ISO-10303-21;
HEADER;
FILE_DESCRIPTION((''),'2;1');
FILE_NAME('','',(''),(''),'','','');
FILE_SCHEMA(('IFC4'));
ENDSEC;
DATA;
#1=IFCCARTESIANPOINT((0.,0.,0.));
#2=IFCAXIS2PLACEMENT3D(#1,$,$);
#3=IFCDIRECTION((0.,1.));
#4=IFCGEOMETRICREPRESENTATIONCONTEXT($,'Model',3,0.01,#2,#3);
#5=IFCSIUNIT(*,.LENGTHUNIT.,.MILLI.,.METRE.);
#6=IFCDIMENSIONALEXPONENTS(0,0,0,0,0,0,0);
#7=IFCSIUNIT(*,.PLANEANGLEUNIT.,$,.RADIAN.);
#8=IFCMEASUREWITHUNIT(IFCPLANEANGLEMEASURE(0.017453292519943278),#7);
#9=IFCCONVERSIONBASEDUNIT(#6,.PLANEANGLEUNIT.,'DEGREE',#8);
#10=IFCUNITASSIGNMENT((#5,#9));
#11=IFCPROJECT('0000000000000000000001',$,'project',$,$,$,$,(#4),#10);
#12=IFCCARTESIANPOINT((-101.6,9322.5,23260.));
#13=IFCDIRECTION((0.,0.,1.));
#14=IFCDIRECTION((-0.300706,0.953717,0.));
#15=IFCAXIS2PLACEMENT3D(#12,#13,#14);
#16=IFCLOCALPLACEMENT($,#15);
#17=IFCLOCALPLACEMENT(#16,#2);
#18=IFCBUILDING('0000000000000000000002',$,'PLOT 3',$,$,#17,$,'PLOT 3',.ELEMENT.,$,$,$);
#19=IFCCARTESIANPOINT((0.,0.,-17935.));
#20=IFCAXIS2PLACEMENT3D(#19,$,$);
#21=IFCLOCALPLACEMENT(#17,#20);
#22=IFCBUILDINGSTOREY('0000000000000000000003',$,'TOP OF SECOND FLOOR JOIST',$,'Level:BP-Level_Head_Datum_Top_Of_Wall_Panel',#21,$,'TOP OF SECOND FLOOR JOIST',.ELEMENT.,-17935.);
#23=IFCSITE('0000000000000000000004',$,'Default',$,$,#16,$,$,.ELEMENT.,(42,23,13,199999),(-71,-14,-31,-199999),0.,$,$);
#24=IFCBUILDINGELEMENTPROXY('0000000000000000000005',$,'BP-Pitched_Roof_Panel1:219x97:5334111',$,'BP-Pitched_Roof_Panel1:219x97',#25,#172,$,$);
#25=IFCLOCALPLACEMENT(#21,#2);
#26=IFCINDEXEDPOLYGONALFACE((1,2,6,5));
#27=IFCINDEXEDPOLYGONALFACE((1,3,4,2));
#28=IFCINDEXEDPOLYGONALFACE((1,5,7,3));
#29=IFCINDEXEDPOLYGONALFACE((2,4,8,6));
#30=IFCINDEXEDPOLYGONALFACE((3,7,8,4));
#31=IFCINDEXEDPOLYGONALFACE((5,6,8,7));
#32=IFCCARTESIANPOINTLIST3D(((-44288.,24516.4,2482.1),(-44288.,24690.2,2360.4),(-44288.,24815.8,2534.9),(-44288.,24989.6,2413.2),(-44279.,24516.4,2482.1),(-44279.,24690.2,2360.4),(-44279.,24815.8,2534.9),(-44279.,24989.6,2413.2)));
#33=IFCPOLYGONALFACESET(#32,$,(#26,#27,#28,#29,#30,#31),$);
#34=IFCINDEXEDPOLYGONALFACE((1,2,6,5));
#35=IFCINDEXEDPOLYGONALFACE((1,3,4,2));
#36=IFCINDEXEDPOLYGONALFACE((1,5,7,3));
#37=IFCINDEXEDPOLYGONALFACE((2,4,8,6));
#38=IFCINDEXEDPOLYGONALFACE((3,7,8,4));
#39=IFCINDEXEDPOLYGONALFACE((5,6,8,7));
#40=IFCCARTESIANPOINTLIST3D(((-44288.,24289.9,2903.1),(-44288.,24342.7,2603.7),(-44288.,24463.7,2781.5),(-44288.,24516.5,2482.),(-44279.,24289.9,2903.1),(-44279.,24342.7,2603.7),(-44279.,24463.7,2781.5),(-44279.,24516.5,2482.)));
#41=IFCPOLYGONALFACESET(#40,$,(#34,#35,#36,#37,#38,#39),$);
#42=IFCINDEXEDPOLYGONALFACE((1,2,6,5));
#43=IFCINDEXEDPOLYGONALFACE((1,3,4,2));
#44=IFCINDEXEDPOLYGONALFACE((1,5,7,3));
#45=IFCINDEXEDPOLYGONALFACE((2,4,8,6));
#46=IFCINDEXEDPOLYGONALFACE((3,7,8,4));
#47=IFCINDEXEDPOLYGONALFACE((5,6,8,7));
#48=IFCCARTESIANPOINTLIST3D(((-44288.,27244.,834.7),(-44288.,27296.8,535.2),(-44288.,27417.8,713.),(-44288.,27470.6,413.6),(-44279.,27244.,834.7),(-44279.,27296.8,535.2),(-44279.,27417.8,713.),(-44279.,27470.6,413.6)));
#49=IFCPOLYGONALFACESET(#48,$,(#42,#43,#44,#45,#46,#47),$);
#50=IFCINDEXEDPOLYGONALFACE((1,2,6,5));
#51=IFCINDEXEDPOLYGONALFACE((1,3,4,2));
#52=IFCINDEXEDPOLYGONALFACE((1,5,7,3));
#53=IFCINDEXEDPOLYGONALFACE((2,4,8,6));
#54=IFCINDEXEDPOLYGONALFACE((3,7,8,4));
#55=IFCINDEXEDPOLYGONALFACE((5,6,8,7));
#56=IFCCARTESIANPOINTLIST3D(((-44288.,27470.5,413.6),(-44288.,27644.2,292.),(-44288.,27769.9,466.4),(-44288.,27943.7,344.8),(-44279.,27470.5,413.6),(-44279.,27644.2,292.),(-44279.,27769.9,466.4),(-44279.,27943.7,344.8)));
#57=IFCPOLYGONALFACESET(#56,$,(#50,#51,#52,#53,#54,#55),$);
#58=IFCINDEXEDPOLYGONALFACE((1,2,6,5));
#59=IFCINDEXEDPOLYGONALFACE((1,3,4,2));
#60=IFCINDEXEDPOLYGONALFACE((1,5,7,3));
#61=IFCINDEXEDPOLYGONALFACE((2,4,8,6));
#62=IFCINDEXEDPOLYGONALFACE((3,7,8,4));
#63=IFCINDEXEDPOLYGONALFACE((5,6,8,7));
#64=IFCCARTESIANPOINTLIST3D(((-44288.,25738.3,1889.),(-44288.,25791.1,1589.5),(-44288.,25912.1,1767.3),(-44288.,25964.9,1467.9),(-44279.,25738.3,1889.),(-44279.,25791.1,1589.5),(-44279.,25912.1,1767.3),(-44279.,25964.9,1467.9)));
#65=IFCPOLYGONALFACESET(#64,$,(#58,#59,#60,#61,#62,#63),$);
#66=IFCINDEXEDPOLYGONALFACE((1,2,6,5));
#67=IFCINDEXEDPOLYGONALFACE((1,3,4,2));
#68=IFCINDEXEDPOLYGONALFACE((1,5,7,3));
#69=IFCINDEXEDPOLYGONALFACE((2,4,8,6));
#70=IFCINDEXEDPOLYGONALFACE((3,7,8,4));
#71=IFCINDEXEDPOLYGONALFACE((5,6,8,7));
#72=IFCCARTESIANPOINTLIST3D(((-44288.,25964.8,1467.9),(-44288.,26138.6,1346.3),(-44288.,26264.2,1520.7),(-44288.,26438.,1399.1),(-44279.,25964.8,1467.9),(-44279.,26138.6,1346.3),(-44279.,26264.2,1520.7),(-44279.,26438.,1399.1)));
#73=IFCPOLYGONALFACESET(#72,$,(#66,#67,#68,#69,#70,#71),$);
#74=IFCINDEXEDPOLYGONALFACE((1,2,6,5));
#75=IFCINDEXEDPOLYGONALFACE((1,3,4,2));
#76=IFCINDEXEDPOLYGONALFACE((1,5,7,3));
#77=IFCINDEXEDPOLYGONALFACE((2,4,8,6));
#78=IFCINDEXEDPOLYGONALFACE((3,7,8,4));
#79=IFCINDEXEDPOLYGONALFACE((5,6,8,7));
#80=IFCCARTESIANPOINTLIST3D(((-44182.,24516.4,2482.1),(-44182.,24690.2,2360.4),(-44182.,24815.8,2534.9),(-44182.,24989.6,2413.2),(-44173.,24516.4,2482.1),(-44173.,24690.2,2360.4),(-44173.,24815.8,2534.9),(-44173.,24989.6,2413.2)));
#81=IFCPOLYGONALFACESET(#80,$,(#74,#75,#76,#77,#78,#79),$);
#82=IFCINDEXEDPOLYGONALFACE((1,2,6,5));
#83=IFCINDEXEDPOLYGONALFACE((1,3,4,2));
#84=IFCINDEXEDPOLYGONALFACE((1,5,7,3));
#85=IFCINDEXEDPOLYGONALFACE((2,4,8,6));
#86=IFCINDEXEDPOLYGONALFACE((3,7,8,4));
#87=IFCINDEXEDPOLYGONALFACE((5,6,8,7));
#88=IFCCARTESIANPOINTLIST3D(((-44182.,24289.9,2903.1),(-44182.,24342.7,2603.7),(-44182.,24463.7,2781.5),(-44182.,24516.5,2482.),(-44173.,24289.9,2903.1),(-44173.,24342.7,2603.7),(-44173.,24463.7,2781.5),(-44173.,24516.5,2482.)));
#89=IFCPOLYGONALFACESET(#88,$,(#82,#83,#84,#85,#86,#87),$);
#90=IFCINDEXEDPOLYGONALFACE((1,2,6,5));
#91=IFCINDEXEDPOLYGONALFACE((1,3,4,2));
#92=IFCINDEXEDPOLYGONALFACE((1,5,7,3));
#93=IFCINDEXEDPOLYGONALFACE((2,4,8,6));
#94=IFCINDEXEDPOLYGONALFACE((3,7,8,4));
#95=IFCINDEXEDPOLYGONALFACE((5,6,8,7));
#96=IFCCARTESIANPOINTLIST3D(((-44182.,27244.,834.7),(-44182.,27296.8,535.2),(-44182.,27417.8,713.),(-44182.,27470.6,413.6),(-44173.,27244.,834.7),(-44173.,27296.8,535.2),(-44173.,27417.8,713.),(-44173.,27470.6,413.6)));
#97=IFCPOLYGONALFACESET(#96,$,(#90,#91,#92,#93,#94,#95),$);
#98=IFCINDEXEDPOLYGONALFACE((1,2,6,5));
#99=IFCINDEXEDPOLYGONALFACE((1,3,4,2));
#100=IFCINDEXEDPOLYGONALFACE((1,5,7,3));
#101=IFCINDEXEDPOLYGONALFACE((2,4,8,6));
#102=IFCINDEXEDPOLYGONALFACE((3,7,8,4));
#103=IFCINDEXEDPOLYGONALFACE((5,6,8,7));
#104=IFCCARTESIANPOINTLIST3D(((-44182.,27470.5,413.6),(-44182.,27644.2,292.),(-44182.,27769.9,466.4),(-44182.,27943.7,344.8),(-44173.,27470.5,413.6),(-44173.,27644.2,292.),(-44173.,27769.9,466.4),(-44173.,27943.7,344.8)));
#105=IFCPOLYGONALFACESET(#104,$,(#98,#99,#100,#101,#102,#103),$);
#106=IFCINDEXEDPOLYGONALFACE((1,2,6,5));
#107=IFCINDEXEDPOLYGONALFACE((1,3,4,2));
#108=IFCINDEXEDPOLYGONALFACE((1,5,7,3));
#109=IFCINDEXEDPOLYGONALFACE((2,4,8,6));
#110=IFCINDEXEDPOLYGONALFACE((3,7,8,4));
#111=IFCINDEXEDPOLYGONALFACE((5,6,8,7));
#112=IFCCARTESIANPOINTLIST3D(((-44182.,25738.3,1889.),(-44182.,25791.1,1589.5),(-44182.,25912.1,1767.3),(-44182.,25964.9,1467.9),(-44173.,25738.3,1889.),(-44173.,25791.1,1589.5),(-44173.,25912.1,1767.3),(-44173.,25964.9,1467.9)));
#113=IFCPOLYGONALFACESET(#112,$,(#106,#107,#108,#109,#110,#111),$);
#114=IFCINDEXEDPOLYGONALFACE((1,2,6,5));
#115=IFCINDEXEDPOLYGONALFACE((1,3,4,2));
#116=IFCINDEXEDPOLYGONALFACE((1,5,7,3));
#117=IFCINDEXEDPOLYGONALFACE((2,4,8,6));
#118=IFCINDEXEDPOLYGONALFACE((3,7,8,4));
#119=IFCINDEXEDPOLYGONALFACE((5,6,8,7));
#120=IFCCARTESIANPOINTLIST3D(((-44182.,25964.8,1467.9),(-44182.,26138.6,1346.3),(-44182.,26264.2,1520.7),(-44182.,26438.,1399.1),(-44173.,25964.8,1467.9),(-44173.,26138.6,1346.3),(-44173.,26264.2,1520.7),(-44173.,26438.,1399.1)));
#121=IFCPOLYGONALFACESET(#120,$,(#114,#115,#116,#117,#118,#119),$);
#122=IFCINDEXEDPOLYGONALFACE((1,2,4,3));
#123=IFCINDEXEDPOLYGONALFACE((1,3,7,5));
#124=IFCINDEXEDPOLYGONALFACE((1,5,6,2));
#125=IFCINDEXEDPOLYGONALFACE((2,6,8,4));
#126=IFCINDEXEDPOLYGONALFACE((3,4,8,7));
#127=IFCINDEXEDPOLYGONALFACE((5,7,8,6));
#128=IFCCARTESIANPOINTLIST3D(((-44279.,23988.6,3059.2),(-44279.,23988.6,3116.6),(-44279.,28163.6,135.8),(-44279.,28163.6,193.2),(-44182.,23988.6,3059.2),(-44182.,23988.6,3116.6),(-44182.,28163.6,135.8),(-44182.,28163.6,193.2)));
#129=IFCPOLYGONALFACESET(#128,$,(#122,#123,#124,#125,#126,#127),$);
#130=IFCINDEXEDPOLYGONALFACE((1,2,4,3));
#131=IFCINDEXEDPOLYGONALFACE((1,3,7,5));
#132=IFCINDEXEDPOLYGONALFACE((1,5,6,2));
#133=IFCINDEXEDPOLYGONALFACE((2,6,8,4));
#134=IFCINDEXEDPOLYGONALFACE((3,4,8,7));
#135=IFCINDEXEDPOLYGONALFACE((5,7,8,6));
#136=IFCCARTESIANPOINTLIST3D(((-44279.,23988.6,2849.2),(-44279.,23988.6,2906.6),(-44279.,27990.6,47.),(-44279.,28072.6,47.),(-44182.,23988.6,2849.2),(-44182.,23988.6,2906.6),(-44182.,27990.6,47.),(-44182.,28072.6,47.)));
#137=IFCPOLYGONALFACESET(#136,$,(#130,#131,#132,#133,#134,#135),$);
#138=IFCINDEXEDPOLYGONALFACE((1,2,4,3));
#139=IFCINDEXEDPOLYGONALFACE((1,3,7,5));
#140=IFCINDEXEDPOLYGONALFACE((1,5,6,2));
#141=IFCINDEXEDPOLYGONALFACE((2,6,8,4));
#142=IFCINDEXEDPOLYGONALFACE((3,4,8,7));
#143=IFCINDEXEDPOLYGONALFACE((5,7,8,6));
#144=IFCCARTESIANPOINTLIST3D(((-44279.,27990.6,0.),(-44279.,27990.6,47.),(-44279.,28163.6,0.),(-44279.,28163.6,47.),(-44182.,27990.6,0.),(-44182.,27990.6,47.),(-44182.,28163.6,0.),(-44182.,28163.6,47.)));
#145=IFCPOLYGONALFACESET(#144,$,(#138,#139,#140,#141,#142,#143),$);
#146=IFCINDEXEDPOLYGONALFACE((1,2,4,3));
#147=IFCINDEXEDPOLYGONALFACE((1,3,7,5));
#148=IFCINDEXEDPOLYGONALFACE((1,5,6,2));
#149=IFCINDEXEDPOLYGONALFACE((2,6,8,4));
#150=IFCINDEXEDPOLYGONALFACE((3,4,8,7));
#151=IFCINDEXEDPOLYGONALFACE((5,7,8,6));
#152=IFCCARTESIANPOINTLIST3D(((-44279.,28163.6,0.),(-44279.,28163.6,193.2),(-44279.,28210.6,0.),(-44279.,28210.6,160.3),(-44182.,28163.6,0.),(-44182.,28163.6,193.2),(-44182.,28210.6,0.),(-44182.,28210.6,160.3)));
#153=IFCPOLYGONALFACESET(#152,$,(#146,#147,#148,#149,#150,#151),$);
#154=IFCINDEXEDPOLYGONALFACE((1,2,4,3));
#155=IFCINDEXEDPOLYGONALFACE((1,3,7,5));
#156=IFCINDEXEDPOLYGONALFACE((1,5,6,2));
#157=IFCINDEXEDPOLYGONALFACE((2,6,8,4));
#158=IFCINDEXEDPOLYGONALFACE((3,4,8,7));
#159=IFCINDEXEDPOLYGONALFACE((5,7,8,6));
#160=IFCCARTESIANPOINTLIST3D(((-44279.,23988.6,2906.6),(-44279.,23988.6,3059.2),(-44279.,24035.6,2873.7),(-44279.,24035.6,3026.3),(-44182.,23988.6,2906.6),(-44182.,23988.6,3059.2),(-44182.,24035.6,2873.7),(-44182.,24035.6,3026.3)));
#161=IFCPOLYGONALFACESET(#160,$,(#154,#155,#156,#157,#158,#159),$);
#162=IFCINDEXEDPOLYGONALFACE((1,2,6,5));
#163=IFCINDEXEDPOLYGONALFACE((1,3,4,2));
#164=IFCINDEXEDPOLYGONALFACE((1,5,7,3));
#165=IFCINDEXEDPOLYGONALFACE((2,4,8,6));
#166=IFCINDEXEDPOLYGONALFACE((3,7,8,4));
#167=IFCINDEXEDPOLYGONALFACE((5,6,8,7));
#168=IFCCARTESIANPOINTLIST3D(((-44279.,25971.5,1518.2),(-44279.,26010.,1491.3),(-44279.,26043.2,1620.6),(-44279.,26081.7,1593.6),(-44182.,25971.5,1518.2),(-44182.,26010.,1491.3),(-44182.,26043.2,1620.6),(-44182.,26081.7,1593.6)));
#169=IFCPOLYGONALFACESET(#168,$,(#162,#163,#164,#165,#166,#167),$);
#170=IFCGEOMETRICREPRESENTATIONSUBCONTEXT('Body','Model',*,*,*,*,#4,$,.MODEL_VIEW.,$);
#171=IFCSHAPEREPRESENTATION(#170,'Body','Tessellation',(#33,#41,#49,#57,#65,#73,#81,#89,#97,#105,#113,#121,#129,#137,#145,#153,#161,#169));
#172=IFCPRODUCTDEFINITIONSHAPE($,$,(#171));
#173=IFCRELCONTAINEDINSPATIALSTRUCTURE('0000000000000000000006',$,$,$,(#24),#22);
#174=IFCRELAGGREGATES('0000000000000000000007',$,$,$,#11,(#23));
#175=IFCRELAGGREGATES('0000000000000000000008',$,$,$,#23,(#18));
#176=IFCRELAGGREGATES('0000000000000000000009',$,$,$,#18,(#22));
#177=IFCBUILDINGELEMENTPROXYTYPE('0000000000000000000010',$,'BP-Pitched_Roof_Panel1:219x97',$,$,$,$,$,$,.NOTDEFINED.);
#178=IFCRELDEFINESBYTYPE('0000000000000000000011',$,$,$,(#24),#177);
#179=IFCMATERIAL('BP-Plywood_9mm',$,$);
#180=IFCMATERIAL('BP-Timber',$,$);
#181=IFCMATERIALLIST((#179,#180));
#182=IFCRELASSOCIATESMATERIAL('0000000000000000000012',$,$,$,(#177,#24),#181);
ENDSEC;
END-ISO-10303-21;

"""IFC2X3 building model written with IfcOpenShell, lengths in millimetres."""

from ifc_helpers import new_model, entity, si_unit, converted_unit, direction, frame, frame_2d, origin, origin_2d_with_axis, place, context, subcontext, project, spatial, polyline, rectangle, outline, extrude, source, transform, mapped, material, material_list, type_object, type_shapes, element, save


model = new_model("IFC2X3")

# Units and contexts
model_context = context("Model", 3, precision=0.01, world=origin(), true_north=direction((0.0, 1.0)))
body_context = subcontext(model_context, "Body", "Model", "MODEL_VIEW")
ifc_project = project(units=[si_unit("LENGTHUNIT", "METRE", prefix="MILLI"), converted_unit("PLANEANGLEUNIT", "DEGREE", entity("IfcPlaneAngleMeasure", 0.017453292519943278), si_unit("PLANEANGLEUNIT", "RADIAN"), dimensions=[0, 0, 0, 0, 0, 0, 0])], contexts=[model_context])

# Site, building, storey
site_placement = place(None, frame((-101.6, 9322.5, 23260.0), z_axis=(0.0, 0.0, 1.0), x_axis=(-0.300706, 0.953717, 0.0)))
site = spatial("IfcSite", under=ifc_project, at=site_placement, Name="Default", CompositionType="ELEMENT", RefLatitude=(42, 23, 13, 199999), RefLongitude=(-71, -14, -31, -199999), RefElevation=0.0)
building_placement = place(site_placement, origin())
building = spatial("IfcBuilding", under=site, at=building_placement, Name="PLOT 3", LongName="PLOT 3", CompositionType="ELEMENT")
storey_placement = place(building_placement, frame((0.0, 0.0, -17935.0)))
storey = spatial("IfcBuildingStorey", under=building, at=storey_placement, Name="TOP OF SECOND FLOOR JOIST", ObjectType="Level:BP-Level_Head_Datum_Top_Of_Wall_Panel", LongName="TOP OF SECOND FLOOR JOIST", CompositionType="ELEMENT", Elevation=-17935.0)

# Building element proxy
ifc_material_1 = material(Name="BP-Timber")
ifc_material_2 = material(Name="BP-Plywood_9mm")
ifc_material_list = material_list([ifc_material_2, ifc_material_1])
building_element_proxy_type_1 = type_object("IfcBuildingElementProxyType", Name="BP-Pitched_Roof_Panel1:219x97", PredefinedType="NOTDEFINED", material=ifc_material_list)
shared_shape_1 = source(origin(), body_context, "Body", "SweptSolid", [
    extrude(outline(polyline([(-77.0, -75.0), (227.0, -75.0), (77.0, 75.0), (-227.0, 75.0), (-77.0, -75.0)])), frame((35.3, -3956.0, 2447.7), z_axis=(0.0, 1.0, 0.0), x_axis=(-0.984808, 0.0, 0.173648)), (0.0, 0.0, 1.0), 9.0),
    extrude(outline(polyline([(1.4, -107.5), (213.6, -107.5), (-1.4, 107.5), (-213.6, 107.5), (1.4, -107.5)])), frame((385.1, -3956.0, 2692.6), z_axis=(0.0, 1.0, 0.0), x_axis=(-0.819152, 0.0, -0.573576)), (0.0, 0.0, 1.0), 9.0),
    extrude(outline(polyline([(1.4, -107.5), (213.6, -107.5), (-1.4, 107.5), (-213.6, 107.5), (1.4, -107.5)])), frame((-2569.0, -3956.0, 624.1), z_axis=(0.0, 1.0, 0.0), x_axis=(-0.819152, 0.0, -0.573576)), (0.0, 0.0, 1.0), 9.0),
    extrude(outline(polyline([(-77.0, -75.0), (227.0, -75.0), (77.0, 75.0), (-227.0, 75.0), (-77.0, -75.0)])), frame((-2918.8, -3956.0, 379.2), z_axis=(0.0, 1.0, 0.0), x_axis=(-0.984808, 0.0, 0.173648)), (0.0, 0.0, 1.0), 9.0),
    extrude(outline(polyline([(1.4, -107.5), (213.6, -107.5), (-1.4, 107.5), (-213.6, 107.5), (1.4, -107.5)])), frame((-1063.3, -3956.0, 1678.4), z_axis=(0.0, 1.0, 0.0), x_axis=(-0.819152, 0.0, -0.573576)), (0.0, 0.0, 1.0), 9.0),
    extrude(outline(polyline([(-77.0, -75.0), (227.0, -75.0), (77.0, 75.0), (-227.0, 75.0), (-77.0, -75.0)])), frame((-1413.1, -3956.0, 1433.5), z_axis=(0.0, 1.0, 0.0), x_axis=(-0.984808, 0.0, 0.173648)), (0.0, 0.0, 1.0), 9.0),
    extrude(outline(polyline([(-77.0, -75.0), (227.0, -75.0), (77.0, 75.0), (-227.0, 75.0), (-77.0, -75.0)])), frame((35.3, -3850.0, 2447.7), z_axis=(0.0, 1.0, 0.0), x_axis=(-0.984808, 0.0, 0.173648)), (0.0, 0.0, 1.0), 9.0),
    extrude(outline(polyline([(1.4, -107.5), (213.6, -107.5), (-1.4, 107.5), (-213.6, 107.5), (1.4, -107.5)])), frame((385.1, -3850.0, 2692.6), z_axis=(0.0, 1.0, 0.0), x_axis=(-0.819152, 0.0, -0.573576)), (0.0, 0.0, 1.0), 9.0),
    extrude(outline(polyline([(1.4, -107.5), (213.6, -107.5), (-1.4, 107.5), (-213.6, 107.5), (1.4, -107.5)])), frame((-2569.0, -3850.0, 624.1), z_axis=(0.0, 1.0, 0.0), x_axis=(-0.819152, 0.0, -0.573576)), (0.0, 0.0, 1.0), 9.0),
    extrude(outline(polyline([(-77.0, -75.0), (227.0, -75.0), (77.0, 75.0), (-227.0, 75.0), (-77.0, -75.0)])), frame((-2918.8, -3850.0, 379.2), z_axis=(0.0, 1.0, 0.0), x_axis=(-0.984808, 0.0, 0.173648)), (0.0, 0.0, 1.0), 9.0),
    extrude(outline(polyline([(1.4, -107.5), (213.6, -107.5), (-1.4, 107.5), (-213.6, 107.5), (1.4, -107.5)])), frame((-1063.3, -3850.0, 1678.4), z_axis=(0.0, 1.0, 0.0), x_axis=(-0.819152, 0.0, -0.573576)), (0.0, 0.0, 1.0), 9.0),
    extrude(outline(polyline([(-77.0, -75.0), (227.0, -75.0), (77.0, 75.0), (-227.0, 75.0), (-77.0, -75.0)])), frame((-1413.1, -3850.0, 1433.5), z_axis=(0.0, 1.0, 0.0), x_axis=(-0.984808, 0.0, 0.173648)), (0.0, 0.0, 1.0), 9.0),
    extrude(outline(polyline([(-1490.4, -2087.5), (-1433.0, -2087.5), (1490.4, 2087.5), (1433.0, 2087.5), (-1490.4, -2087.5)])), frame((-1287.8, -3947.0, 1626.2), z_axis=(0.0, 1.0, 0.0), x_axis=(0.0, 0.0, -1.0)), (0.0, 0.0, 1.0), 97.0),
    extrude(outline(polyline([(-1444.1, -2021.5), (-1386.8, -2021.5), (1415.5, 1980.5), (1415.5, 2062.5), (-1444.1, -2021.5)])), frame((-1221.8, -3947.0, 1462.5), z_axis=(0.0, 1.0, 0.0), x_axis=(0.0, 0.0, -1.0)), (0.0, 0.0, 1.0), 97.0),
    extrude(rectangle(XDim=173.0, YDim=97.0, at=origin_2d_with_axis()), frame((-3288.8, -3898.5, 0.0), z_axis=(0.0, 0.0, 1.0), x_axis=(-1.0, 0.0, 0.0)), (0.0, 0.0, 1.0), 47.0),
    extrude(outline(polyline([(22.0, -72.4), (79.4, -72.4), (-31.4, 85.9), (-69.9, 58.9), (22.0, -72.4)])), frame((-3398.8, -3947.0, 88.4), z_axis=(0.0, 1.0, 0.0), x_axis=(0.819152, 0.0, 0.573576)), (0.0, 0.0, 1.0), 97.0),
    extrude(outline(polyline([(15.1, -62.5), (72.5, -62.5), (-15.1, 62.5), (-72.5, 62.5), (15.1, -62.5)])), frame((776.2, -3947.0, 2966.5), z_axis=(0.0, 1.0, 0.0), x_axis=(0.819152, 0.0, 0.573576)), (0.0, 0.0, 1.0), 97.0),
    extrude(rectangle(XDim=47.0, YDim=97.0, at=frame_2d((0.0, 0.0), x_axis=(1.0, 0.0))), frame((-1202.4, -3898.5, 1504.7), z_axis=(-0.573576, 0.0, 0.819152), x_axis=(-0.819152, 0.0, -0.573576)), (0.0, 0.0, 1.0), 125.0),
])
type_shapes(building_element_proxy_type_1, [shared_shape_1])
for number, where, z_axis, x_axis, name in (
    (1, (-40332.0, 24788.3, 0.0), (0.0, 0.0, 1.0), (0.0, -1.0, 0.0), "BP-Pitched_Roof_Panel1:219x97:5334111"),
):
    element("IfcBuildingElementProxy", number, at=place(storey_placement, frame(where, z_axis=z_axis, x_axis=x_axis)), inside=storey, type_object=building_element_proxy_type_1, material=ifc_material_list, Name=name, ObjectType="BP-Pitched_Roof_Panel1:219x97", context=body_context, shape_type="MappedRepresentation", body=[
        mapped(shared_shape_1, transform((0.0, 0.0, 0.0), scale=1.0)),
    ])

save(model, "model.ifc")
